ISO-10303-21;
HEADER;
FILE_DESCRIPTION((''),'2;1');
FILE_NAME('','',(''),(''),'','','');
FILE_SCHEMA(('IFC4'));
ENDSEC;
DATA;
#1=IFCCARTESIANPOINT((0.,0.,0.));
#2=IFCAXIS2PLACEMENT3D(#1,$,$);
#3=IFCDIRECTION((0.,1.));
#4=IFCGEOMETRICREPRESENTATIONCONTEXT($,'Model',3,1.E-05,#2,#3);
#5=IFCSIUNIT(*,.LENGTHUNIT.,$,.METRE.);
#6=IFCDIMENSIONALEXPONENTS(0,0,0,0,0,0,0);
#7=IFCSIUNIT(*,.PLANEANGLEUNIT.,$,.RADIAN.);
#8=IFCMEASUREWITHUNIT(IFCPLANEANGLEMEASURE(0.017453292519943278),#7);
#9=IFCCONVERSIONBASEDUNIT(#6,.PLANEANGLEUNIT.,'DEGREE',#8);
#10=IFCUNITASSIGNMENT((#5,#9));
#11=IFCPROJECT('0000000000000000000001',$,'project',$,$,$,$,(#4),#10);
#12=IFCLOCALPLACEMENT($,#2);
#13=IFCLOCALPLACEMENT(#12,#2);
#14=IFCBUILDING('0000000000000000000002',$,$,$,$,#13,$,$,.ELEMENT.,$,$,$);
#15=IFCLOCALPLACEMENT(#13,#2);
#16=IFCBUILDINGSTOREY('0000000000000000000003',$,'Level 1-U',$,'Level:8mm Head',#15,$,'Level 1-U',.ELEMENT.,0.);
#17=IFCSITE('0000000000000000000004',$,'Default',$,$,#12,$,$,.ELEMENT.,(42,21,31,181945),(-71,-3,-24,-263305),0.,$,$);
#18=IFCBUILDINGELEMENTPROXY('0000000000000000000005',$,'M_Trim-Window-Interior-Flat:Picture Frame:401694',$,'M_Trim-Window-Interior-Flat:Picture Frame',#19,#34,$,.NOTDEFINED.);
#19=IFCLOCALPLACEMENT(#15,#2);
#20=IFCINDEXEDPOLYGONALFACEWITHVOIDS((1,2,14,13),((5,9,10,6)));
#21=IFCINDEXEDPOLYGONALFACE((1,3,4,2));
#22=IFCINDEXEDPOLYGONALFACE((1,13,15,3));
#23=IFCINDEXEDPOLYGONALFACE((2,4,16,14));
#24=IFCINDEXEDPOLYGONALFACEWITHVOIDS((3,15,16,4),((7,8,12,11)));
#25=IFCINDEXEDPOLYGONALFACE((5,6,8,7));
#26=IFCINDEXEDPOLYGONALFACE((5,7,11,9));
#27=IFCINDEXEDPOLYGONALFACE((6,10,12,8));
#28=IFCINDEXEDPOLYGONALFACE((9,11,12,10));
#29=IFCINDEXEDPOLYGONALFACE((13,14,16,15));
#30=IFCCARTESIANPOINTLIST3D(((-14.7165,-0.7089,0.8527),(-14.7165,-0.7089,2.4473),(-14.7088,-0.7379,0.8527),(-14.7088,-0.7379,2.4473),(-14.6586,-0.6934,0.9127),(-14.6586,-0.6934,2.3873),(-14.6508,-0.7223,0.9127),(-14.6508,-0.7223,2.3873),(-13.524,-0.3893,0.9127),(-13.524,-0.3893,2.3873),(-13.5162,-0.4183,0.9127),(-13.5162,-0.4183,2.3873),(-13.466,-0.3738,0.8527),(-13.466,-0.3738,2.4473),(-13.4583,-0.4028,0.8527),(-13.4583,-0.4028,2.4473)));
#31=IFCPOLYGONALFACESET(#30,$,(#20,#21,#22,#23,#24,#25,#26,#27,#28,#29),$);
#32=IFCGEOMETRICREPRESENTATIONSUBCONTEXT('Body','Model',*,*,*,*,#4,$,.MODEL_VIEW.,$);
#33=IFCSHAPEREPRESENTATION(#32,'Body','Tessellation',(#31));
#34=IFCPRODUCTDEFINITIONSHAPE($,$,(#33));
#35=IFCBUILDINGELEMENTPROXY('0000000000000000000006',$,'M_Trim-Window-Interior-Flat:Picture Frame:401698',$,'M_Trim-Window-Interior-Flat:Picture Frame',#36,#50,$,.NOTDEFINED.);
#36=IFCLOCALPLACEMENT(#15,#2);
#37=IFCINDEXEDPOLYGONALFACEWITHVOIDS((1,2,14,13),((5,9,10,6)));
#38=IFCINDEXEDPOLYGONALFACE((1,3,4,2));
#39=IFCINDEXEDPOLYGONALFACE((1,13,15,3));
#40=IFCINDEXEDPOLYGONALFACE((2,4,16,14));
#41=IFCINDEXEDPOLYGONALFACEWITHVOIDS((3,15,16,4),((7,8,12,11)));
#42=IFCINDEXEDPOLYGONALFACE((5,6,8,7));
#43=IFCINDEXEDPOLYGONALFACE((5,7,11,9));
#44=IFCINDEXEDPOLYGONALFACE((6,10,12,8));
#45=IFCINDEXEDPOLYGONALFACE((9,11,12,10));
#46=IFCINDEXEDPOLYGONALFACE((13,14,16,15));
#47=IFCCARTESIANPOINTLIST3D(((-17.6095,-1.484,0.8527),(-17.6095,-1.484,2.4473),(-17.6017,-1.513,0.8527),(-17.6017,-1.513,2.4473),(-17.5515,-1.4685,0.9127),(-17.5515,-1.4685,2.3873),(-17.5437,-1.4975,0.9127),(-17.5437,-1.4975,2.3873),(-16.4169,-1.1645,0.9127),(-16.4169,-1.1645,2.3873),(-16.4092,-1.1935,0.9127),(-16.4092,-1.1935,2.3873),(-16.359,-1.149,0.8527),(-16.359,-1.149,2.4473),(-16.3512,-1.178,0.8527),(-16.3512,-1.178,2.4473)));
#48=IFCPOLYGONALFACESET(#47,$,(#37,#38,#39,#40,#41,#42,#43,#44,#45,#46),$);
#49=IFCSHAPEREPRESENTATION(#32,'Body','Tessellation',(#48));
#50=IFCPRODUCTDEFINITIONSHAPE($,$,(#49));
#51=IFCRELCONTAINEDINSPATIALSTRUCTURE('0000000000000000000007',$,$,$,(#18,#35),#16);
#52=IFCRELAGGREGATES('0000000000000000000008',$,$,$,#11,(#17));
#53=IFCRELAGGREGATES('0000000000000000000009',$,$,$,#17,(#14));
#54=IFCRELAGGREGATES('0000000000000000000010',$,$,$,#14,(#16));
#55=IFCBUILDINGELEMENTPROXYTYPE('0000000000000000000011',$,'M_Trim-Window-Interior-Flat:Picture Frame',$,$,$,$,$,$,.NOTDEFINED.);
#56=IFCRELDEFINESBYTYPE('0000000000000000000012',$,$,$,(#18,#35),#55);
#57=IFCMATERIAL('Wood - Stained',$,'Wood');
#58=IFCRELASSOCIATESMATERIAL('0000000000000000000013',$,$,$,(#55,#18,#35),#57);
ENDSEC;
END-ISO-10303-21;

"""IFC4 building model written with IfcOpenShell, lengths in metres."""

from ifc_helpers import new_model, entity, si_unit, converted_unit, direction, frame, origin, place, context, subcontext, project, spatial, polyline, outline, extrude, source, transform, mapped, material, type_object, type_shapes, element, save


model = new_model("IFC4")

# Units and contexts
model_context = context("Model", 3, precision=1e-05, world=origin(), true_north=direction((0.0, 1.0)))
body_context = subcontext(model_context, "Body", "Model", "MODEL_VIEW")
ifc_project = project(units=[si_unit("LENGTHUNIT", "METRE"), converted_unit("PLANEANGLEUNIT", "DEGREE", entity("IfcPlaneAngleMeasure", 0.017453292519943278), si_unit("PLANEANGLEUNIT", "RADIAN"), dimensions=[0, 0, 0, 0, 0, 0, 0])], contexts=[model_context])

# Site, building, storey
site_placement = place(None, origin())
site = spatial("IfcSite", under=ifc_project, at=site_placement, Name="Default", CompositionType="ELEMENT", RefLatitude=(42, 21, 31, 181945), RefLongitude=(-71, -3, -24, -263305), RefElevation=0.0)
building_placement = place(site_placement, origin())
building = spatial("IfcBuilding", under=site, at=building_placement, CompositionType="ELEMENT")
storey_placement = place(building_placement, origin())
storey = spatial("IfcBuildingStorey", under=building, at=storey_placement, Name="Level 1-U", ObjectType="Level:8mm Head", LongName="Level 1-U", CompositionType="ELEMENT", Elevation=0.0)

# Building element proxies
ifc_material_1 = material(Name="Wood - Stained", Category="Wood")
building_element_proxy_type_1 = type_object("IfcBuildingElementProxyType", Name="M_Trim-Window-Interior-Flat:Picture Frame", PredefinedType="NOTDEFINED", material=ifc_material_1)
shared_shape_1 = source(origin(), body_context, "Body", "SweptSolid", [
    extrude(outline(polyline([(-0.6473, -0.7973), (0.6473, -0.7973), (0.6473, 0.7973), (-0.6473, 0.7973), (-0.6473, -0.7973)]), holes=[polyline([(-0.5873, -0.7373), (-0.5873, 0.7373), (0.5873, 0.7373), (0.5873, -0.7373), (-0.5873, -0.7373)])]), frame((0.0, -0.75, 0.0), z_axis=(0.0, 0.0, 1.0), x_axis=(-1.0, 0.0, 0.0)), (0.0, 0.0, 1.0), 0.03),
])
type_shapes(building_element_proxy_type_1, [shared_shape_1])
for number, where, z_axis, x_axis, name in (
    (1, (-14.0835, -0.5703, 2.4), (-0.258819, 0.965926, 0.0), (-0.965926, -0.258819, 0.0), "M_Trim-Window-Interior-Flat:Picture Frame:401694"),
    (2, (-16.9765, -1.3455, 2.4), (-0.258819, 0.965926, 0.0), (-0.965926, -0.258819, 0.0), "M_Trim-Window-Interior-Flat:Picture Frame:401698"),
):
    element("IfcBuildingElementProxy", number, at=place(storey_placement, frame(where, z_axis=z_axis, x_axis=x_axis)), inside=storey, type_object=building_element_proxy_type_1, material=ifc_material_1, Name=name, ObjectType="M_Trim-Window-Interior-Flat:Picture Frame", PredefinedType="NOTDEFINED", context=body_context, shape_type="MappedRepresentation", body=[
        mapped(shared_shape_1, transform((0.0, 0.0, 0.0), scale=1.0)),
    ])

save(model, "model.ifc")
